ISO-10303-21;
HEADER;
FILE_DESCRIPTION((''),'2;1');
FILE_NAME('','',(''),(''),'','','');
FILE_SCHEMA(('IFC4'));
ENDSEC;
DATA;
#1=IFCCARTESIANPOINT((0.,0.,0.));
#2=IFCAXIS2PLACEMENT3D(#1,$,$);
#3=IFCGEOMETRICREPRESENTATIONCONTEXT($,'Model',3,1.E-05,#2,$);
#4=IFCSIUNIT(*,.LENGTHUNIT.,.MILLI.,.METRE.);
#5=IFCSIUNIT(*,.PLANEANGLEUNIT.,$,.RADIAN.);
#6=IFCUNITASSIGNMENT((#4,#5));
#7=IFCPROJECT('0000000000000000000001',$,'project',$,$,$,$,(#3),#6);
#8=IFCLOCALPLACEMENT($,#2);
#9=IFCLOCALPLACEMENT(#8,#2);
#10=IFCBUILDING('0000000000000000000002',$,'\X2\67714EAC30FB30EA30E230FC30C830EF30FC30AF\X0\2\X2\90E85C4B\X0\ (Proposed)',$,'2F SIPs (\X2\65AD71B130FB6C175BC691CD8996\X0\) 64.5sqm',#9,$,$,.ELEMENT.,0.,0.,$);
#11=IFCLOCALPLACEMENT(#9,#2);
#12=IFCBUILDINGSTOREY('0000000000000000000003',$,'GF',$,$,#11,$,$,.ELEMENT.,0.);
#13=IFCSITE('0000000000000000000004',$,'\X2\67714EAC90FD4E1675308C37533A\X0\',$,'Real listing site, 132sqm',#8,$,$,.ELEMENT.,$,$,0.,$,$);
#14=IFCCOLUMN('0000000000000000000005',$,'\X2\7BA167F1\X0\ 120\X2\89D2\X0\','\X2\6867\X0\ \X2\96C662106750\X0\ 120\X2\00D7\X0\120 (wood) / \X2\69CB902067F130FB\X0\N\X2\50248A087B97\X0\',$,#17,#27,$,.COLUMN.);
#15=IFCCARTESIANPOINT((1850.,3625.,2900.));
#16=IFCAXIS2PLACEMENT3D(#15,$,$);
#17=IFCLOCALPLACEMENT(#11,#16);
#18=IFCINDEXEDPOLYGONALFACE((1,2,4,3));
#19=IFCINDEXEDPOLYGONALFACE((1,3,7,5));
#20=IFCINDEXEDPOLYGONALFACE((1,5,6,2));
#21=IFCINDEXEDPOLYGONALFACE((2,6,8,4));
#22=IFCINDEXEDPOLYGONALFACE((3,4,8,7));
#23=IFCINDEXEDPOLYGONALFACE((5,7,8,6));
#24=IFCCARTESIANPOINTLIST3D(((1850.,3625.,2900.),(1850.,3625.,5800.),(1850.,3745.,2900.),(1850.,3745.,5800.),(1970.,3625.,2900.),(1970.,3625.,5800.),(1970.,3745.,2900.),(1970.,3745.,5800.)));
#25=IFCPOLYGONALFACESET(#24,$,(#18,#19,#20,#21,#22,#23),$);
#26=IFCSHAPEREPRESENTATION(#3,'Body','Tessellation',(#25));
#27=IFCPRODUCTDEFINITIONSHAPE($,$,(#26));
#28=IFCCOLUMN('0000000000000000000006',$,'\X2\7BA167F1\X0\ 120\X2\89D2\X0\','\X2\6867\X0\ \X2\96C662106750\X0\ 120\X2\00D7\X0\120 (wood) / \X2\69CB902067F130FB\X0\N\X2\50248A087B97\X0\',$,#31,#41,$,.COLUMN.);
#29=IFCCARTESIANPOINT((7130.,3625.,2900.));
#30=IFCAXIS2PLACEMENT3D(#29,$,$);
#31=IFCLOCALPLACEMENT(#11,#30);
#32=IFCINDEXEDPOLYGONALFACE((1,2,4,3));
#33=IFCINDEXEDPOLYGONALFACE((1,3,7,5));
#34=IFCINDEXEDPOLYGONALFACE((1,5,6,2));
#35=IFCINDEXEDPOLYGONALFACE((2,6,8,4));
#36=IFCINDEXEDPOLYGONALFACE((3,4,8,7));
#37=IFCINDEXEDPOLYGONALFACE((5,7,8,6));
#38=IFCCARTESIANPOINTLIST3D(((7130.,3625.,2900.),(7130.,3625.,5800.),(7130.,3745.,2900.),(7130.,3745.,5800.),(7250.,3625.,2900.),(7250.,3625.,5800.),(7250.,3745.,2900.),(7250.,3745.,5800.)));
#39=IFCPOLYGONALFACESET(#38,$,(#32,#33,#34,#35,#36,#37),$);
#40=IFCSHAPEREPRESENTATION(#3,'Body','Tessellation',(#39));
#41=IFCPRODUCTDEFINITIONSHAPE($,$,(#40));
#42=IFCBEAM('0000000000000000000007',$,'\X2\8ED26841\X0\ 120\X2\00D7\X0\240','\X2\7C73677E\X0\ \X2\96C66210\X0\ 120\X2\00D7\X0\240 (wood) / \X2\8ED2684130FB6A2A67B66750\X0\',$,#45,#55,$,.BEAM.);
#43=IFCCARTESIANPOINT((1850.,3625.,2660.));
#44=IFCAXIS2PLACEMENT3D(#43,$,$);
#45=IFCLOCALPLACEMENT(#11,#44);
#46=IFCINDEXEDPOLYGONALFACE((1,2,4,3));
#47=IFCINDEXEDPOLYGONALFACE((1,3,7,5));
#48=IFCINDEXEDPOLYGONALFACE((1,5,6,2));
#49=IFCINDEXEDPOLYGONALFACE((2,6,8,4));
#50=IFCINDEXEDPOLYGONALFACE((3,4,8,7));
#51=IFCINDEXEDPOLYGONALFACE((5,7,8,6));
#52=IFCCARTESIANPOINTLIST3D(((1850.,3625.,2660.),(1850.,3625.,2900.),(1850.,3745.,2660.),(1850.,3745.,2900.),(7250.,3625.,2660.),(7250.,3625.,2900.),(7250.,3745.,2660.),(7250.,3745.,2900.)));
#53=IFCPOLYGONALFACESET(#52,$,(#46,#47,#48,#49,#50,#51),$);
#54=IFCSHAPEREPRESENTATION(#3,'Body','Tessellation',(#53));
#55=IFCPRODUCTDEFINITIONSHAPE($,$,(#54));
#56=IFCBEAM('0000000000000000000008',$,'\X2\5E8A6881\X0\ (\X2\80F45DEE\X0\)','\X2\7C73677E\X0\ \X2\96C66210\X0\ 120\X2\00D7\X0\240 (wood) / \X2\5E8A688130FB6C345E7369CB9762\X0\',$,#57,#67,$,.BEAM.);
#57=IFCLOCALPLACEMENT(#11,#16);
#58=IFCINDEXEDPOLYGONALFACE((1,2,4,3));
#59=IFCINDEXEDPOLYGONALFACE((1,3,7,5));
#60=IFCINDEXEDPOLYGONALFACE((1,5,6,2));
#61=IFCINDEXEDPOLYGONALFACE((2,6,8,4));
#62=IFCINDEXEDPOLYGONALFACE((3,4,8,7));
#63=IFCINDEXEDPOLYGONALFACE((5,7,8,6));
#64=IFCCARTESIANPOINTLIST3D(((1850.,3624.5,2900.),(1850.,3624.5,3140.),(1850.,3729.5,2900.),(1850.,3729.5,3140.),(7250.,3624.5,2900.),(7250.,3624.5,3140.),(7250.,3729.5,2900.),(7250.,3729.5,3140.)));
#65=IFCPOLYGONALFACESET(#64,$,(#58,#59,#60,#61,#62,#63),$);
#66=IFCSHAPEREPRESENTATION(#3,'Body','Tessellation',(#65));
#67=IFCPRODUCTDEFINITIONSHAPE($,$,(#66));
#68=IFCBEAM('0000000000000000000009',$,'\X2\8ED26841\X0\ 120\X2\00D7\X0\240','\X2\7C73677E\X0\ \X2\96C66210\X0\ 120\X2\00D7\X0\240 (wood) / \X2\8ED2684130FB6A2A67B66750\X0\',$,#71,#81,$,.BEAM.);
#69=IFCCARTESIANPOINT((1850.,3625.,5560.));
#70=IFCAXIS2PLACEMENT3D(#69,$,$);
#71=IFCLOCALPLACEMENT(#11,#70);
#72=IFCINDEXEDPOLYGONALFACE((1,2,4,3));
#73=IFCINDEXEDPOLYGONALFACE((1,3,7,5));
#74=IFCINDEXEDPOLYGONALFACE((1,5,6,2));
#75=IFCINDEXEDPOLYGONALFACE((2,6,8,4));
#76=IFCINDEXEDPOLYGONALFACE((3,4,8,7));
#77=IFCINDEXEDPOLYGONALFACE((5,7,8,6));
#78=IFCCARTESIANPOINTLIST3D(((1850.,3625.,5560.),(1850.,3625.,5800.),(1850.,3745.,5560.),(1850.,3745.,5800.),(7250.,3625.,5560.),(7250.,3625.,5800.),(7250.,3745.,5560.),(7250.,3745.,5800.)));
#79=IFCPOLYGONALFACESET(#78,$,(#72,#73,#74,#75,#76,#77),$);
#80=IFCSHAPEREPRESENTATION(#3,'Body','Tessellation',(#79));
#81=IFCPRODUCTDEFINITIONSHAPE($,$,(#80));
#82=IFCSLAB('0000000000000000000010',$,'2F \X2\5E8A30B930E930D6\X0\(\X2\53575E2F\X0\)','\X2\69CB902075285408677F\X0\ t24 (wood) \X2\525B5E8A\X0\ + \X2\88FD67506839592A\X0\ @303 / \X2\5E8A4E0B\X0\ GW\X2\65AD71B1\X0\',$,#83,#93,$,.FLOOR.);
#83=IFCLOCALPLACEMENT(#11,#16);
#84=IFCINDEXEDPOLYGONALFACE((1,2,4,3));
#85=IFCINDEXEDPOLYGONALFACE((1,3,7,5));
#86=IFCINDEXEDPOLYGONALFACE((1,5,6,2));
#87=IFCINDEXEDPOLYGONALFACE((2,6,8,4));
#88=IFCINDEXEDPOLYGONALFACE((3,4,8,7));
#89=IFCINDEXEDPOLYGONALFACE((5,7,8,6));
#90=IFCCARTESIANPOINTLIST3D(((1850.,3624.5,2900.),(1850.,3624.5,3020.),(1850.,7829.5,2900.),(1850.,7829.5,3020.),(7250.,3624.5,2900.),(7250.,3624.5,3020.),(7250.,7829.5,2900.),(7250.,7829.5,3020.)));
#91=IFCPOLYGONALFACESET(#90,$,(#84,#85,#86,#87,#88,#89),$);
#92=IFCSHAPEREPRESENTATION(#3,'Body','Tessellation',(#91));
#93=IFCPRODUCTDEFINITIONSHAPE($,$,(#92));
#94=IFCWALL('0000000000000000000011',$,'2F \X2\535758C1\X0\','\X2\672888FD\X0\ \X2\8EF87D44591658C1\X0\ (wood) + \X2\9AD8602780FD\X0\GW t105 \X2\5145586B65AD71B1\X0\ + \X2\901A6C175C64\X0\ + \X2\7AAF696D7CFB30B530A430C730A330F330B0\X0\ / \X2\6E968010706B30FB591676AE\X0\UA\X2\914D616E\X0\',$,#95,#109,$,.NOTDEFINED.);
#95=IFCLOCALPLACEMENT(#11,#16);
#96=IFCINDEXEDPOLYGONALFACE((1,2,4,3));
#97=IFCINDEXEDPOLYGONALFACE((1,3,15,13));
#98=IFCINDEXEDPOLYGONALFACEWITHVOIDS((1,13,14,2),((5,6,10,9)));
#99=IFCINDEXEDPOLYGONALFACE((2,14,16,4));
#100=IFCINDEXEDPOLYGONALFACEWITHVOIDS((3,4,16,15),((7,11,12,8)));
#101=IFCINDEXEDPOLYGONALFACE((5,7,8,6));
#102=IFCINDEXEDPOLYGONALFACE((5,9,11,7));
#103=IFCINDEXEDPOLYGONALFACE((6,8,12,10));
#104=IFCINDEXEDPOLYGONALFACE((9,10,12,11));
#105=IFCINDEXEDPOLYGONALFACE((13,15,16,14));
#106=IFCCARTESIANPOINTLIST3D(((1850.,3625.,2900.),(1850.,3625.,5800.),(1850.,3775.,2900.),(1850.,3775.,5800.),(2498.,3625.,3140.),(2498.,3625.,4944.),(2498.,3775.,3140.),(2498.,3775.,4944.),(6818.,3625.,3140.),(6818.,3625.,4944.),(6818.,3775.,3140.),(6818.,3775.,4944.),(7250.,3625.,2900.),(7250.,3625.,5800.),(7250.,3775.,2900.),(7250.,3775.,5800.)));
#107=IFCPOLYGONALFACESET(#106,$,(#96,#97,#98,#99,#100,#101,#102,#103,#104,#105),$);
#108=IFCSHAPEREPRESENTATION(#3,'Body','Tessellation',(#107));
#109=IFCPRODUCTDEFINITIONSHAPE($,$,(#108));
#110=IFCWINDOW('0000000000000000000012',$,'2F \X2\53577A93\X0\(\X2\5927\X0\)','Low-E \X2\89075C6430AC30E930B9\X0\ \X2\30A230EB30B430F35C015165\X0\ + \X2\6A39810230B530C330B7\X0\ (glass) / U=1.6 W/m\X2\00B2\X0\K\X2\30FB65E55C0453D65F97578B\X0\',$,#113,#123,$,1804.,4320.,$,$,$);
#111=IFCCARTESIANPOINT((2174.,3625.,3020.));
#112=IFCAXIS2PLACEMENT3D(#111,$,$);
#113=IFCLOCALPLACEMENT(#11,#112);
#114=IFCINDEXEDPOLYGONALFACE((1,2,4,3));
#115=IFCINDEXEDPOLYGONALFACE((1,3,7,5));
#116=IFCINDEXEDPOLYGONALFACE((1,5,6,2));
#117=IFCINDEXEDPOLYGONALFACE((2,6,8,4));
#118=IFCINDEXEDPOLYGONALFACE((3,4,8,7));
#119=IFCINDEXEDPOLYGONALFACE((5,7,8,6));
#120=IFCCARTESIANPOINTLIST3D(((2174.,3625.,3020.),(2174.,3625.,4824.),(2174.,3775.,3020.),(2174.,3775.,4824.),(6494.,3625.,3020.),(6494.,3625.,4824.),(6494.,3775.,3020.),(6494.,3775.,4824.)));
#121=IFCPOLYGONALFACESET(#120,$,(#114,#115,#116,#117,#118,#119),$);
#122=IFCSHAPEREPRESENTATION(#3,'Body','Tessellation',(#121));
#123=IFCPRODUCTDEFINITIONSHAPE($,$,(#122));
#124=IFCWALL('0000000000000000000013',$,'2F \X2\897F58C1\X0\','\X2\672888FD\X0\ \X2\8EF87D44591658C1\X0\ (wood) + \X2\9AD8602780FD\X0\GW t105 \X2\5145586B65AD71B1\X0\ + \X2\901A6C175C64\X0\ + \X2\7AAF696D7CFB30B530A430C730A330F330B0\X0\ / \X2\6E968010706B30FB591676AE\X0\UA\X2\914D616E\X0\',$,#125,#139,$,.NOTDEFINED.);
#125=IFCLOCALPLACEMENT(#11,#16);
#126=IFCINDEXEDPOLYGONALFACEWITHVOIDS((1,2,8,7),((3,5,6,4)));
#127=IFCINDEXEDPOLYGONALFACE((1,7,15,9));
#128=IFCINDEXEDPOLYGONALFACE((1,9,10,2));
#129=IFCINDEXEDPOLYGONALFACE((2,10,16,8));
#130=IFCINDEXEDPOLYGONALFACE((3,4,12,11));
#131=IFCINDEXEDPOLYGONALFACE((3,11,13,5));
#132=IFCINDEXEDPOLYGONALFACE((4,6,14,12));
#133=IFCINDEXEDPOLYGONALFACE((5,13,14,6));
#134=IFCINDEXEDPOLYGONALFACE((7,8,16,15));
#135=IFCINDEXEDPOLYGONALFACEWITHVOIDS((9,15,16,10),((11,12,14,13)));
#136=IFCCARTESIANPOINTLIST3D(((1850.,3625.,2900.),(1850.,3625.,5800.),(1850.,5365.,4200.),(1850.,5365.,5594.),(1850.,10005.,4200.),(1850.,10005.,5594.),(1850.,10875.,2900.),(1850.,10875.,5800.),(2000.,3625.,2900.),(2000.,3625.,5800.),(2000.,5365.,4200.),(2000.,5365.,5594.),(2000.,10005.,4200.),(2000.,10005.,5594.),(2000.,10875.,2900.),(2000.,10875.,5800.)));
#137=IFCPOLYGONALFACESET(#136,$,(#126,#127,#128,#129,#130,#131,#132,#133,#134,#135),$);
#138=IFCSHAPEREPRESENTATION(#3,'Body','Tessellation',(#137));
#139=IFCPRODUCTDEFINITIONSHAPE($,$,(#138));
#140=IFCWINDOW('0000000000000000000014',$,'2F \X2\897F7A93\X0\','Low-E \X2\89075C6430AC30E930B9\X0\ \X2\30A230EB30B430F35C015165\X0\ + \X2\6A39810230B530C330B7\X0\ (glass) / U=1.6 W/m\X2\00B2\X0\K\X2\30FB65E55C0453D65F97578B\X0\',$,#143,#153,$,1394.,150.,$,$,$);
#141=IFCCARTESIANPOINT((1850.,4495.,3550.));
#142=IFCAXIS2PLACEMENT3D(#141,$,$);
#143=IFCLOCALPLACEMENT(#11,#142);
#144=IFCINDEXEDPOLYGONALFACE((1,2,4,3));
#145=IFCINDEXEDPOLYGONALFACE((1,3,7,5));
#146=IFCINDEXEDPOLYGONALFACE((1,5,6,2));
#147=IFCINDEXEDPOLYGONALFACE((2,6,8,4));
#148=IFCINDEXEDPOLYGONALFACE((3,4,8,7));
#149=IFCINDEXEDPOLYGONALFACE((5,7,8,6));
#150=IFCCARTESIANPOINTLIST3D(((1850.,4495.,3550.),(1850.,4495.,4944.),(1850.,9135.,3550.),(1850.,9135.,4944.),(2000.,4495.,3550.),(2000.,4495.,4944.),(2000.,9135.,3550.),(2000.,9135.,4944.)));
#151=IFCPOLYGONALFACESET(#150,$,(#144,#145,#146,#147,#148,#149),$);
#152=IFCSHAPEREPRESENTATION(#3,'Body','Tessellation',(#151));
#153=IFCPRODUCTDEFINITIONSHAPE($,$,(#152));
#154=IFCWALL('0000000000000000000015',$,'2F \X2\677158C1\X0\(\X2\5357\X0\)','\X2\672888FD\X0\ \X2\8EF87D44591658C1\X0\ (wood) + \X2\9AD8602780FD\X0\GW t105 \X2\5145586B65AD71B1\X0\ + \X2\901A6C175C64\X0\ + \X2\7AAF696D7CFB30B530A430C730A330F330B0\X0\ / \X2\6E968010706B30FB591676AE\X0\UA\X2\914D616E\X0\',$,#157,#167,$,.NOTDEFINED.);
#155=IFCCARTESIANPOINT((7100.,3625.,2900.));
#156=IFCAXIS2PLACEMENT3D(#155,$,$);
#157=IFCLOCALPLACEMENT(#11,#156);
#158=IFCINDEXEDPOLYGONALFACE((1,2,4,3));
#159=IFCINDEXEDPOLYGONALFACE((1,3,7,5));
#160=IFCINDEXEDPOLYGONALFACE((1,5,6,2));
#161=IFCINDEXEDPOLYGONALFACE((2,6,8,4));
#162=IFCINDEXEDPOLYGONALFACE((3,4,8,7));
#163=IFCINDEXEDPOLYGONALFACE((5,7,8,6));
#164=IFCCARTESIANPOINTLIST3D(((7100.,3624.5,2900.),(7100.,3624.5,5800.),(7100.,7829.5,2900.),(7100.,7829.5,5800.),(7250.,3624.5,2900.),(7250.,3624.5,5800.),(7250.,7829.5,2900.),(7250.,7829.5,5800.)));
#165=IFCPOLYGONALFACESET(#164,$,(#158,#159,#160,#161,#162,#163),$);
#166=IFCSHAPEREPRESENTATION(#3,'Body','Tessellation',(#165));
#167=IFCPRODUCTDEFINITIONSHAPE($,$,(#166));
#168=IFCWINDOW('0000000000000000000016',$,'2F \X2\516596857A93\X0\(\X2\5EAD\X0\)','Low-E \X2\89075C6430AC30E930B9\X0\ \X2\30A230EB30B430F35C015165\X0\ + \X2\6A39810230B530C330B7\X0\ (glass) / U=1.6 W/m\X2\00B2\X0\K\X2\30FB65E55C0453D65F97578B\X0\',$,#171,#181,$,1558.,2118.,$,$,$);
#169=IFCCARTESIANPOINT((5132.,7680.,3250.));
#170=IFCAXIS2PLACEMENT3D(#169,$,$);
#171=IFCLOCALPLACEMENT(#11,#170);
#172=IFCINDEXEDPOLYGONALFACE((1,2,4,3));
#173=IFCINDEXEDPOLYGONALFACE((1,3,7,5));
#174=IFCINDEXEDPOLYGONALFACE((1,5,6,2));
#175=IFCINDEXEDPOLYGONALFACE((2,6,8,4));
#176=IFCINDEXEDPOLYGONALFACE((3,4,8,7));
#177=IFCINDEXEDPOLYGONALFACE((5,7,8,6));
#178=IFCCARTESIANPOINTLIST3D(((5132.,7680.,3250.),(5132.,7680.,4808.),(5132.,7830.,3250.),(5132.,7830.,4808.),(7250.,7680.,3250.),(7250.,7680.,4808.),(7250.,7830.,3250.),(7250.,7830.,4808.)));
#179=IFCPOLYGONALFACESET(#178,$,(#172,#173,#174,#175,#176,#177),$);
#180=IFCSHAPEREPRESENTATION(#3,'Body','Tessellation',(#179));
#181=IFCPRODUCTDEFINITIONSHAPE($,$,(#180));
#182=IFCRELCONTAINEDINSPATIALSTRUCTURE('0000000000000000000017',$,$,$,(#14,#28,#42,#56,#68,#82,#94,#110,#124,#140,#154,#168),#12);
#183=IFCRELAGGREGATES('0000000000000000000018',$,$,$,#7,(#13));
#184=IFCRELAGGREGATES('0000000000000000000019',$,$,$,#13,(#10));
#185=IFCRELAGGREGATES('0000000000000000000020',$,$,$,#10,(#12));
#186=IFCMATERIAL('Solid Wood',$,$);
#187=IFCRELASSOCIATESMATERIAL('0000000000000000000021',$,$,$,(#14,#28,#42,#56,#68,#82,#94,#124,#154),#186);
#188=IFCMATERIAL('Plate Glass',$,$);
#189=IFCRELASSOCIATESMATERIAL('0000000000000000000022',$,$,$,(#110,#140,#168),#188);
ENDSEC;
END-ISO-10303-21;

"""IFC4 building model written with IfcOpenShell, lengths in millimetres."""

from ifc_helpers import new_model, si_unit, frame, frame_2d, origin, place, context, project, spatial, rectangle, extrude, material, element, fill, save


model = new_model("IFC4")

# Units and contexts
model_context = context("Model", 3, precision=1e-05, world=origin())
ifc_project = project(units=[si_unit("LENGTHUNIT", "METRE", prefix="MILLI"), si_unit("PLANEANGLEUNIT", "RADIAN")], contexts=[model_context])

# Site, building, storey
site_placement = place(None, origin())
site = spatial("IfcSite", under=ifc_project, at=site_placement, Name="東京都世田谷区", ObjectType="Real listing site, 132sqm", CompositionType="ELEMENT", RefElevation=0.0)
building_placement = place(site_placement, origin())
building = spatial("IfcBuilding", under=site, at=building_placement, Name="東京・リモートワーク2部屋 (Proposed)", ObjectType="2F SIPs (断熱・気密重視) 64.5sqm", CompositionType="ELEMENT", ElevationOfRefHeight=0.0, ElevationOfTerrain=0.0)
storey_placement = place(building_placement, origin())
storey = spatial("IfcBuildingStorey", under=building, at=storey_placement, Name="GF", CompositionType="ELEMENT", Elevation=0.0)

# Columns
ifc_material_1 = material(Name="Solid Wood")
column_1_placement = place(storey_placement, frame((1850.0, 3625.0, 2900.0)))
element("IfcColumn", 1, at=column_1_placement, inside=storey, material=ifc_material_1, Name="管柱 120角", Description="桧 集成材 120×120 (wood) / 構造柱・N値計算", PredefinedType="COLUMN", context=model_context, shape_type="SweptSolid", body=[
    extrude(rectangle(XDim=120.0, YDim=120.0, at=frame_2d((60.0, 60.0))), frame((1850.0, 3625.0, 2900.0)), (0.0, 0.0, 1.0), 2900.0),
])
column_2_placement = place(storey_placement, frame((7130.0, 3625.0, 2900.0)))
element("IfcColumn", 2, at=column_2_placement, inside=storey, material=ifc_material_1, Name="管柱 120角", Description="桧 集成材 120×120 (wood) / 構造柱・N値計算", PredefinedType="COLUMN", context=model_context, shape_type="SweptSolid", body=[
    extrude(rectangle(XDim=120.0, YDim=120.0, at=frame_2d((60.0, 60.0))), frame((7130.0, 3625.0, 2900.0)), (0.0, 0.0, 1.0), 2900.0),
])

# Beams
beam_1_placement = place(storey_placement, frame((1850.0, 3625.0, 2660.0)))
element("IfcBeam", 3, at=beam_1_placement, inside=storey, material=ifc_material_1, Name="軒桁 120×240", Description="米松 集成 120×240 (wood) / 軒桁・横架材", PredefinedType="BEAM", context=model_context, shape_type="SweptSolid", body=[
    extrude(rectangle(XDim=5400.0, YDim=120.0, at=frame_2d((2700.0, 60.0))), frame((1850.0, 3625.0, 2660.0)), (0.0, 0.0, 1.0), 240.0),
])
beam_2_placement = place(storey_placement, frame((1850.0, 3625.0, 2900.0)))
element("IfcBeam", 4, at=beam_2_placement, inside=storey, material=ifc_material_1, Name="床梁 (胴差)", Description="米松 集成 120×240 (wood) / 床梁・水平構面", PredefinedType="BEAM", context=model_context, shape_type="SweptSolid", body=[
    extrude(rectangle(XDim=5400.0, YDim=105.0, at=frame_2d((2700.0, 52.0))), frame((1850.0, 3625.0, 2900.0)), (0.0, 0.0, 1.0), 240.0),
])
beam_3_placement = place(storey_placement, frame((1850.0, 3625.0, 5560.0)))
element("IfcBeam", 5, at=beam_3_placement, inside=storey, material=ifc_material_1, Name="軒桁 120×240", Description="米松 集成 120×240 (wood) / 軒桁・横架材", PredefinedType="BEAM", context=model_context, shape_type="SweptSolid", body=[
    extrude(rectangle(XDim=5400.0, YDim=120.0, at=frame_2d((2700.0, 60.0))), frame((1850.0, 3625.0, 5560.0)), (0.0, 0.0, 1.0), 240.0),
])

# Slab
slab_placement = place(storey_placement, frame((1850.0, 3625.0, 2900.0)))
element("IfcSlab", 6, at=slab_placement, inside=storey, material=ifc_material_1, Name="2F 床スラブ(南帯)", Description="構造用合板 t24 (wood) 剛床 + 製材根太 @303 / 床下 GW断熱", PredefinedType="FLOOR", context=model_context, shape_type="SweptSolid", body=[
    extrude(rectangle(XDim=5400.0, YDim=4205.0, at=frame_2d((2700.0, 2102.0))), frame((1850.0, 3625.0, 2900.0)), (0.0, 0.0, 1.0), 120.0),
])

# Walls, openings, windows
wall_1_placement = place(storey_placement, frame((1850.0, 3625.0, 2900.0)))
wall_1 = element("IfcWall", 7, at=wall_1_placement, inside=storey, material=ifc_material_1, Name="2F 南壁", Description="木製 軸組外壁 (wood) + 高性能GW t105 充填断熱 + 通気層 + 窯業系サイディング / 準耐火・外皮UA配慮", PredefinedType="NOTDEFINED", context=model_context, shape_type="SweptSolid", body=[
    extrude(rectangle(XDim=5400.0, YDim=150.0, at=frame_2d((2700.0, 75.0))), frame((1850.0, 3625.0, 2900.0)), (0.0, 0.0, 1.0), 2900.0),
])
opening_1_placement = place(storey_placement, frame((2174.0, 3625.0, 3020.0)))
opening_1 = element("IfcOpeningElement", 8, at=opening_1_placement, cuts=wall_1, PredefinedType="NOTDEFINED", context=model_context, shape_type="SweptSolid", body=[
    extrude(rectangle(XDim=4320.0, YDim=150.0, at=frame_2d((2160.0, 75.0))), frame((2174.0, 3625.0, 3020.0)), (0.0, 0.0, 1.0), 1804.0),
])
ifc_material_2 = material(Name="Plate Glass")
window_1_placement = place(storey_placement, frame((2174.0, 3625.0, 3020.0)))
window_1 = element("IfcWindow", 9, at=window_1_placement, inside=storey, material=ifc_material_2, Name="2F 南窓(大)", Description="Low-E 複層ガラス アルゴン封入 + 樹脂サッシ (glass) / U=1.6 W/m²K・日射取得型", OverallHeight=1804.0, OverallWidth=4320.0, context=model_context, shape_type="SweptSolid", body=[
    extrude(rectangle(XDim=4320.0, YDim=150.0, at=frame_2d((2160.0, 75.0))), frame((2174.0, 3625.0, 3020.0)), (0.0, 0.0, 1.0), 1804.0),
])
fill(opening_1, window_1)
wall_2_placement = place(storey_placement, frame((1850.0, 3625.0, 2900.0)))
wall_2 = element("IfcWall", 10, at=wall_2_placement, inside=storey, material=ifc_material_1, Name="2F 西壁", Description="木製 軸組外壁 (wood) + 高性能GW t105 充填断熱 + 通気層 + 窯業系サイディング / 準耐火・外皮UA配慮", PredefinedType="NOTDEFINED", context=model_context, shape_type="SweptSolid", body=[
    extrude(rectangle(XDim=150.0, YDim=7250.0, at=frame_2d((75.0, 3625.0))), frame((1850.0, 3625.0, 2900.0)), (0.0, 0.0, 1.0), 2900.0),
])
opening_2_placement = place(storey_placement, frame((1850.0, 4495.0, 3550.0)))
opening_2 = element("IfcOpeningElement", 11, at=opening_2_placement, cuts=wall_2, PredefinedType="NOTDEFINED", context=model_context, shape_type="SweptSolid", body=[
    extrude(rectangle(XDim=150.0, YDim=4640.0, at=frame_2d((75.0, 2320.0))), frame((1850.0, 4495.0, 3550.0)), (0.0, 0.0, 1.0), 1394.0),
])
window_2_placement = place(storey_placement, frame((1850.0, 4495.0, 3550.0)))
window_2 = element("IfcWindow", 12, at=window_2_placement, inside=storey, material=ifc_material_2, Name="2F 西窓", Description="Low-E 複層ガラス アルゴン封入 + 樹脂サッシ (glass) / U=1.6 W/m²K・日射取得型", OverallHeight=1394.0, OverallWidth=150.0, context=model_context, shape_type="SweptSolid", body=[
    extrude(rectangle(XDim=150.0, YDim=4640.0, at=frame_2d((75.0, 2320.0))), frame((1850.0, 4495.0, 3550.0)), (0.0, 0.0, 1.0), 1394.0),
])
fill(opening_2, window_2)
wall_3_placement = place(storey_placement, frame((7100.0, 3625.0, 2900.0)))
wall_3 = element("IfcWall", 13, at=wall_3_placement, inside=storey, material=ifc_material_1, Name="2F 東壁(南)", Description="木製 軸組外壁 (wood) + 高性能GW t105 充填断熱 + 通気層 + 窯業系サイディング / 準耐火・外皮UA配慮", PredefinedType="NOTDEFINED", context=model_context, shape_type="SweptSolid", body=[
    extrude(rectangle(XDim=150.0, YDim=4205.0, at=frame_2d((75.0, 2102.0))), frame((7100.0, 3625.0, 2900.0)), (0.0, 0.0, 1.0), 2900.0),
])
opening_3_placement = place(storey_placement, frame((5132.0, 7680.0, 3250.0)))
opening_3 = element("IfcOpeningElement", 14, at=opening_3_placement, cuts=wall_3, PredefinedType="NOTDEFINED", context=model_context, shape_type="SweptSolid", body=[
    extrude(rectangle(XDim=2118.0, YDim=150.0, at=frame_2d((1059.0, 75.0))), frame((5132.0, 7680.0, 3250.0)), (0.0, 0.0, 1.0), 1558.0),
])
window_3_placement = place(storey_placement, frame((5132.0, 7680.0, 3250.0)))
window_3 = element("IfcWindow", 15, at=window_3_placement, inside=storey, material=ifc_material_2, Name="2F 入隅窓(庭)", Description="Low-E 複層ガラス アルゴン封入 + 樹脂サッシ (glass) / U=1.6 W/m²K・日射取得型", OverallHeight=1558.0, OverallWidth=2118.0, context=model_context, shape_type="SweptSolid", body=[
    extrude(rectangle(XDim=2118.0, YDim=150.0, at=frame_2d((1059.0, 75.0))), frame((5132.0, 7680.0, 3250.0)), (0.0, 0.0, 1.0), 1558.0),
])
fill(opening_3, window_3)

save(model, "model.ifc")
